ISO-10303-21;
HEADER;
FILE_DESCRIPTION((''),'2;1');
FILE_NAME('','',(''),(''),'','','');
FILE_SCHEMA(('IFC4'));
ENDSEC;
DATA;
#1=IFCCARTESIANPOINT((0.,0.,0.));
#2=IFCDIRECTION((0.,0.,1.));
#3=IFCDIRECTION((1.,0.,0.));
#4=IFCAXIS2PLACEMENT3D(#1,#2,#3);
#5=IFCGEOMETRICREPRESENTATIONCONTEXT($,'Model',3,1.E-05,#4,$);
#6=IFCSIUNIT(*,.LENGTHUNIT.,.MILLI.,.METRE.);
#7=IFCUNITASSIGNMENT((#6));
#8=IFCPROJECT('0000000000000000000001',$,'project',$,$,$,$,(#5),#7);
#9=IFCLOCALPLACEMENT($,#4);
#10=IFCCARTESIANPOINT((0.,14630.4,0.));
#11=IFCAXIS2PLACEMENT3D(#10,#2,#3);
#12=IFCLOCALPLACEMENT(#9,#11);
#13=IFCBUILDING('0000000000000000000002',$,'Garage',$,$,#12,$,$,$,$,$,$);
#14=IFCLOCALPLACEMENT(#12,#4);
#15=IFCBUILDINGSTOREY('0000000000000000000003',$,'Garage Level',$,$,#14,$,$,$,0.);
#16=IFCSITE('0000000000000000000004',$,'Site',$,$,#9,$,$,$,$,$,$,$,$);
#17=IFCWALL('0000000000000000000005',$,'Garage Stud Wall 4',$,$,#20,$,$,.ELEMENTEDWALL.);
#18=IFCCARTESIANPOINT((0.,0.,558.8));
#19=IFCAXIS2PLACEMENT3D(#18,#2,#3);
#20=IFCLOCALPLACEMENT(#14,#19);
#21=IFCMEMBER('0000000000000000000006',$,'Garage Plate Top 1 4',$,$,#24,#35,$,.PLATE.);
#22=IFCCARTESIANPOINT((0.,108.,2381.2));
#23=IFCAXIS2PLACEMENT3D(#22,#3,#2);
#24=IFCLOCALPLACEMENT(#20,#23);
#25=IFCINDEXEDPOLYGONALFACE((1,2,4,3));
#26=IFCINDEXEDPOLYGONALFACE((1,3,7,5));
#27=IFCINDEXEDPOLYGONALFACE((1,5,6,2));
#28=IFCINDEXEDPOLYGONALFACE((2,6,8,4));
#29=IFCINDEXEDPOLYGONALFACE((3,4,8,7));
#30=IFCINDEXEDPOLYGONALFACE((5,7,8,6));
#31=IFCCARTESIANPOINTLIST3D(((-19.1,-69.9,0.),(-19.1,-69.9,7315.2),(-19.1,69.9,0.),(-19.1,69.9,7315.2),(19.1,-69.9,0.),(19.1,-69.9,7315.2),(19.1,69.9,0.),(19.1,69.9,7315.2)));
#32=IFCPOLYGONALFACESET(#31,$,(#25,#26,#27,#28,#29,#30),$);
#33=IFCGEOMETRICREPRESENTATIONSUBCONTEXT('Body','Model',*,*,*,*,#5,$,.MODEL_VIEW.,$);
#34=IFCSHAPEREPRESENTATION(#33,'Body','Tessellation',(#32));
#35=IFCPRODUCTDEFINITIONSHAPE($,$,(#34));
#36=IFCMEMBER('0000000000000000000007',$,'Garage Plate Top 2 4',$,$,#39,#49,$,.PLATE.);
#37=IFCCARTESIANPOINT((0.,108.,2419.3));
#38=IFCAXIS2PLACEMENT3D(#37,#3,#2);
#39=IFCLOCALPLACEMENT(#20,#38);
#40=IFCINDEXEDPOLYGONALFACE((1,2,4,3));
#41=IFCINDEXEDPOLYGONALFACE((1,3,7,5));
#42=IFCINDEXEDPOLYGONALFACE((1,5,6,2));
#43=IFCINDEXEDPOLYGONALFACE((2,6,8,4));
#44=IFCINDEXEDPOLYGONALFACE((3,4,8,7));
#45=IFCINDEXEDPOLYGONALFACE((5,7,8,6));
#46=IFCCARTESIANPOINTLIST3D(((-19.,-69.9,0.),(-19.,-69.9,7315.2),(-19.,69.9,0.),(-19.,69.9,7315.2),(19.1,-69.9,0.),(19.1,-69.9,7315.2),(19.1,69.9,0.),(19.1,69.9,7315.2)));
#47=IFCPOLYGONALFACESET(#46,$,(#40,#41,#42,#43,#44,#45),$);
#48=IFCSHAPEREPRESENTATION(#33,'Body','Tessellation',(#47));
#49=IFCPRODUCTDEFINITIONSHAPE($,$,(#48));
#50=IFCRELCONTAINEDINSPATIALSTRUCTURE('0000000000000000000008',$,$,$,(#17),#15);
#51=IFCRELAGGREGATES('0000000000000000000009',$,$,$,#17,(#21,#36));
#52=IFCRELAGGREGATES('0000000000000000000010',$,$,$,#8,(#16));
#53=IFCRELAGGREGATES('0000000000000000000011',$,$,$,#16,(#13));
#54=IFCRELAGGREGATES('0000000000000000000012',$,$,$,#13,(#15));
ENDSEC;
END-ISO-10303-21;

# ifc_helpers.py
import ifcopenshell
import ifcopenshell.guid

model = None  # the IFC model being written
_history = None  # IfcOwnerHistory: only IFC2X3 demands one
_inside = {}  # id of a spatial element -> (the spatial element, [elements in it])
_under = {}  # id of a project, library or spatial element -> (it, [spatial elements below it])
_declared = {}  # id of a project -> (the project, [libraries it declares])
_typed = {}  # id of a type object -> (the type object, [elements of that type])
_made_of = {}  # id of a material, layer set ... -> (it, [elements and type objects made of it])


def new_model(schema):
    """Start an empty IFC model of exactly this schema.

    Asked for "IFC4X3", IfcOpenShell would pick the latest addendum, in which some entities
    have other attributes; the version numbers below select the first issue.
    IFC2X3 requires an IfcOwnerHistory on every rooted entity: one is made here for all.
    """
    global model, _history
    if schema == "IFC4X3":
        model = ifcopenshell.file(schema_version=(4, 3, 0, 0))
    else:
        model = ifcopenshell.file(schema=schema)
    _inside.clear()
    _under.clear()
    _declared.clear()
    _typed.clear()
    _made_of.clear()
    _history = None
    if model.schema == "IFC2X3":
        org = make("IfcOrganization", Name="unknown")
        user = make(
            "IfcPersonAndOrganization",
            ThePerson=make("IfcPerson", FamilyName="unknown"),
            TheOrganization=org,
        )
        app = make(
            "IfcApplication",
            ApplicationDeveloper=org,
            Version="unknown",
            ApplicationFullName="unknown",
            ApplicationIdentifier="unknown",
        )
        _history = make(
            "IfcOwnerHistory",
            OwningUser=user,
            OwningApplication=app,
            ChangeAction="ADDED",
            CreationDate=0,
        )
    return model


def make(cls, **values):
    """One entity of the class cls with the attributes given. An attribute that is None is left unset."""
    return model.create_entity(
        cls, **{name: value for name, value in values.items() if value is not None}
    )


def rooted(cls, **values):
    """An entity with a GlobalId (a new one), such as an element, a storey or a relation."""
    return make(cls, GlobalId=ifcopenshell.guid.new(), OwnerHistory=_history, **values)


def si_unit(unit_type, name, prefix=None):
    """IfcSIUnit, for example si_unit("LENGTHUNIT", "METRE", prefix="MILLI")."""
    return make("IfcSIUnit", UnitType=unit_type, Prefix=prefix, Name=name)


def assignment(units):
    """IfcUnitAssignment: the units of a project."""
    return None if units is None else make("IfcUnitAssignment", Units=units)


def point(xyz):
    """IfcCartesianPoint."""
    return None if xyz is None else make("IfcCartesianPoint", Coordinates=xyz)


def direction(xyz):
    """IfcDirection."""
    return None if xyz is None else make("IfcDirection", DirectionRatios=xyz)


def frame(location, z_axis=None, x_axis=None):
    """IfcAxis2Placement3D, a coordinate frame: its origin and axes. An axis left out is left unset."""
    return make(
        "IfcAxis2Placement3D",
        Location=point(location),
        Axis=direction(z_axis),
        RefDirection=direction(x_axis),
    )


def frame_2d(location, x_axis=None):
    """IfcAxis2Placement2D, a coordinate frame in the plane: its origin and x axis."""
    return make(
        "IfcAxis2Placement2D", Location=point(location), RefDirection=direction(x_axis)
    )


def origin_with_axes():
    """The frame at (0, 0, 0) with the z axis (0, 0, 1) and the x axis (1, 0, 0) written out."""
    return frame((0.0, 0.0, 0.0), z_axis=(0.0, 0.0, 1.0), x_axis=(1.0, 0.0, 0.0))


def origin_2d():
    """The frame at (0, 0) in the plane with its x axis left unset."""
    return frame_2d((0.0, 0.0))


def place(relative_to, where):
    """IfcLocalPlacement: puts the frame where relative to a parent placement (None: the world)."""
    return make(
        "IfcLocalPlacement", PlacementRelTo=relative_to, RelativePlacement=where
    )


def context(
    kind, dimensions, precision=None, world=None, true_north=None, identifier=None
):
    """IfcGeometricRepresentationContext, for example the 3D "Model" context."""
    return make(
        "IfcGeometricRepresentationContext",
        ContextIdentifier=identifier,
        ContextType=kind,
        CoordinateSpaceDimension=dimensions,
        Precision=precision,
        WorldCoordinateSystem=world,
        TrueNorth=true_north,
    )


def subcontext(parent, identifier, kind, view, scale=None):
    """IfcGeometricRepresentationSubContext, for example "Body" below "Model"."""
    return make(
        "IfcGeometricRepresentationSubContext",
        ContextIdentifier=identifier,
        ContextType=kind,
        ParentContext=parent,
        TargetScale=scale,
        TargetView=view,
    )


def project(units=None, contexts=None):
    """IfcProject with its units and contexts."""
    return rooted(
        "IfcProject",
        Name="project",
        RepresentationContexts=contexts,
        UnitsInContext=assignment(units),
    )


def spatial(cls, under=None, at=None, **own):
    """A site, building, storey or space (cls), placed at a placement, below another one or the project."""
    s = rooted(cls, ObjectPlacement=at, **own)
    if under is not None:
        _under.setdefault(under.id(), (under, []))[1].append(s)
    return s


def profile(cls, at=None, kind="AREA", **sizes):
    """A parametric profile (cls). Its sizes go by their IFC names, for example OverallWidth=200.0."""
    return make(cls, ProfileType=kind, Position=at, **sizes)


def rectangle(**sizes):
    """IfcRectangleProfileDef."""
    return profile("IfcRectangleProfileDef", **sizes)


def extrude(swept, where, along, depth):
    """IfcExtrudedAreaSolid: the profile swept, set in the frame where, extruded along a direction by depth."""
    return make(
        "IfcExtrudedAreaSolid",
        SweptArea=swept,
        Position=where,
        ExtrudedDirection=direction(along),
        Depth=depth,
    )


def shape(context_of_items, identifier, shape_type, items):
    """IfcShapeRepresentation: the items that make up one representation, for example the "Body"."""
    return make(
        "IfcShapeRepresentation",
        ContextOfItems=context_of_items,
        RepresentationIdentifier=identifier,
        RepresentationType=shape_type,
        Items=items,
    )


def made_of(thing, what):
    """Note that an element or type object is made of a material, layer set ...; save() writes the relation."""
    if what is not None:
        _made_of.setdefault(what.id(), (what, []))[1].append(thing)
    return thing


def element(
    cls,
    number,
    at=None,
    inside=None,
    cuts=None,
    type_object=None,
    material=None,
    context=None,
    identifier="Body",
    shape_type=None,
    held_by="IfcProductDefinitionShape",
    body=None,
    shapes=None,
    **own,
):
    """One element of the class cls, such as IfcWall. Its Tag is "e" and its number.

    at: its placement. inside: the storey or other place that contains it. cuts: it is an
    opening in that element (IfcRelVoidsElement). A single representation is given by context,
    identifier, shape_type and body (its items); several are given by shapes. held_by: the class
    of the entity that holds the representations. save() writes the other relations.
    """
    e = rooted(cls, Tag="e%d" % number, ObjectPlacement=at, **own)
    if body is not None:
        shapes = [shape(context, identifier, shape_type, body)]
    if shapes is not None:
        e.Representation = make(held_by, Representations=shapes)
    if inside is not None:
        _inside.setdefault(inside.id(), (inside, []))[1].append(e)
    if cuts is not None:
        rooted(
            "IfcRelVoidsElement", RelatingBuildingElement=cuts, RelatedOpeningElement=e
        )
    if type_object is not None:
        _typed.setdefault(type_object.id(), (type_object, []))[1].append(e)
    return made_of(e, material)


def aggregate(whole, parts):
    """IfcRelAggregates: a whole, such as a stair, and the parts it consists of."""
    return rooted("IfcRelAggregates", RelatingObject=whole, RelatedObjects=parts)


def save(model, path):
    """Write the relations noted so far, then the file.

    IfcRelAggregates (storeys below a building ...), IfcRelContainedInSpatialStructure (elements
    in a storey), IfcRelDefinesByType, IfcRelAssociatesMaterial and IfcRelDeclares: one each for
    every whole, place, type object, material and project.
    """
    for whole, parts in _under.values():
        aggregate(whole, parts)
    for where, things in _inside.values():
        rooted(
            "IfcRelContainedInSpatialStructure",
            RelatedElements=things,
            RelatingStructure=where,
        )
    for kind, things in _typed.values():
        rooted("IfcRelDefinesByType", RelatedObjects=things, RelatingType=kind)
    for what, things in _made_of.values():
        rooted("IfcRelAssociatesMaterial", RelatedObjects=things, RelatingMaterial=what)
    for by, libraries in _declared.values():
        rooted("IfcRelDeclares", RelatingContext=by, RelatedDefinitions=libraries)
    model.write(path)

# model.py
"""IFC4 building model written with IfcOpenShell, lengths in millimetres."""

from ifc_helpers import new_model, si_unit, frame, origin_with_axes, origin_2d, place, context, subcontext, project, spatial, rectangle, extrude, element, aggregate, save


model = new_model("IFC4")

# Units and contexts
model_context = context("Model", 3, precision=1e-05, world=origin_with_axes())
body_context = subcontext(model_context, "Body", "Model", "MODEL_VIEW")
ifc_project = project(units=[si_unit("LENGTHUNIT", "METRE", prefix="MILLI")], contexts=[model_context])

# Site, building, storey
site_placement = place(None, origin_with_axes())
site = spatial("IfcSite", under=ifc_project, at=site_placement, Name="Site")
building_placement = place(site_placement, frame((0.0, 14630.4, 0.0), z_axis=(0.0, 0.0, 1.0), x_axis=(1.0, 0.0, 0.0)))
building = spatial("IfcBuilding", under=site, at=building_placement, Name="Garage")
storey_placement = place(building_placement, origin_with_axes())
storey = spatial("IfcBuildingStorey", under=building, at=storey_placement, Name="Garage Level", Elevation=0.0)

# Wall, members
wall_1_placement = place(storey_placement, frame((0.0, 0.0, 558.8), z_axis=(0.0, 0.0, 1.0), x_axis=(1.0, 0.0, 0.0)))
wall_1 = element("IfcWall", 1, at=wall_1_placement, inside=storey, Name="Garage Stud Wall 4", PredefinedType="ELEMENTEDWALL")
member_1_placement = place(wall_1_placement, frame((0.0, 108.0, 2381.2), z_axis=(1.0, 0.0, 0.0), x_axis=(0.0, 0.0, 1.0)))
member_1 = element("IfcMember", 2, at=member_1_placement, Name="Garage Plate Top 1 4", PredefinedType="PLATE", context=body_context, shape_type="SweptSolid", body=[
    extrude(rectangle(XDim=38.1, YDim=139.7, at=origin_2d()), origin_with_axes(), (0.0, 0.0, 1.0), 7315.2),
])
member_2_placement = place(wall_1_placement, frame((0.0, 108.0, 2419.3), z_axis=(1.0, 0.0, 0.0), x_axis=(0.0, 0.0, 1.0)))
member_2 = element("IfcMember", 3, at=member_2_placement, Name="Garage Plate Top 2 4", PredefinedType="PLATE", context=body_context, shape_type="SweptSolid", body=[
    extrude(rectangle(XDim=38.1, YDim=139.7, at=origin_2d()), origin_with_axes(), (0.0, 0.0, 1.0), 7315.2),
])
aggregate(wall_1, [member_1, member_2])

save(model, "model.ifc")
